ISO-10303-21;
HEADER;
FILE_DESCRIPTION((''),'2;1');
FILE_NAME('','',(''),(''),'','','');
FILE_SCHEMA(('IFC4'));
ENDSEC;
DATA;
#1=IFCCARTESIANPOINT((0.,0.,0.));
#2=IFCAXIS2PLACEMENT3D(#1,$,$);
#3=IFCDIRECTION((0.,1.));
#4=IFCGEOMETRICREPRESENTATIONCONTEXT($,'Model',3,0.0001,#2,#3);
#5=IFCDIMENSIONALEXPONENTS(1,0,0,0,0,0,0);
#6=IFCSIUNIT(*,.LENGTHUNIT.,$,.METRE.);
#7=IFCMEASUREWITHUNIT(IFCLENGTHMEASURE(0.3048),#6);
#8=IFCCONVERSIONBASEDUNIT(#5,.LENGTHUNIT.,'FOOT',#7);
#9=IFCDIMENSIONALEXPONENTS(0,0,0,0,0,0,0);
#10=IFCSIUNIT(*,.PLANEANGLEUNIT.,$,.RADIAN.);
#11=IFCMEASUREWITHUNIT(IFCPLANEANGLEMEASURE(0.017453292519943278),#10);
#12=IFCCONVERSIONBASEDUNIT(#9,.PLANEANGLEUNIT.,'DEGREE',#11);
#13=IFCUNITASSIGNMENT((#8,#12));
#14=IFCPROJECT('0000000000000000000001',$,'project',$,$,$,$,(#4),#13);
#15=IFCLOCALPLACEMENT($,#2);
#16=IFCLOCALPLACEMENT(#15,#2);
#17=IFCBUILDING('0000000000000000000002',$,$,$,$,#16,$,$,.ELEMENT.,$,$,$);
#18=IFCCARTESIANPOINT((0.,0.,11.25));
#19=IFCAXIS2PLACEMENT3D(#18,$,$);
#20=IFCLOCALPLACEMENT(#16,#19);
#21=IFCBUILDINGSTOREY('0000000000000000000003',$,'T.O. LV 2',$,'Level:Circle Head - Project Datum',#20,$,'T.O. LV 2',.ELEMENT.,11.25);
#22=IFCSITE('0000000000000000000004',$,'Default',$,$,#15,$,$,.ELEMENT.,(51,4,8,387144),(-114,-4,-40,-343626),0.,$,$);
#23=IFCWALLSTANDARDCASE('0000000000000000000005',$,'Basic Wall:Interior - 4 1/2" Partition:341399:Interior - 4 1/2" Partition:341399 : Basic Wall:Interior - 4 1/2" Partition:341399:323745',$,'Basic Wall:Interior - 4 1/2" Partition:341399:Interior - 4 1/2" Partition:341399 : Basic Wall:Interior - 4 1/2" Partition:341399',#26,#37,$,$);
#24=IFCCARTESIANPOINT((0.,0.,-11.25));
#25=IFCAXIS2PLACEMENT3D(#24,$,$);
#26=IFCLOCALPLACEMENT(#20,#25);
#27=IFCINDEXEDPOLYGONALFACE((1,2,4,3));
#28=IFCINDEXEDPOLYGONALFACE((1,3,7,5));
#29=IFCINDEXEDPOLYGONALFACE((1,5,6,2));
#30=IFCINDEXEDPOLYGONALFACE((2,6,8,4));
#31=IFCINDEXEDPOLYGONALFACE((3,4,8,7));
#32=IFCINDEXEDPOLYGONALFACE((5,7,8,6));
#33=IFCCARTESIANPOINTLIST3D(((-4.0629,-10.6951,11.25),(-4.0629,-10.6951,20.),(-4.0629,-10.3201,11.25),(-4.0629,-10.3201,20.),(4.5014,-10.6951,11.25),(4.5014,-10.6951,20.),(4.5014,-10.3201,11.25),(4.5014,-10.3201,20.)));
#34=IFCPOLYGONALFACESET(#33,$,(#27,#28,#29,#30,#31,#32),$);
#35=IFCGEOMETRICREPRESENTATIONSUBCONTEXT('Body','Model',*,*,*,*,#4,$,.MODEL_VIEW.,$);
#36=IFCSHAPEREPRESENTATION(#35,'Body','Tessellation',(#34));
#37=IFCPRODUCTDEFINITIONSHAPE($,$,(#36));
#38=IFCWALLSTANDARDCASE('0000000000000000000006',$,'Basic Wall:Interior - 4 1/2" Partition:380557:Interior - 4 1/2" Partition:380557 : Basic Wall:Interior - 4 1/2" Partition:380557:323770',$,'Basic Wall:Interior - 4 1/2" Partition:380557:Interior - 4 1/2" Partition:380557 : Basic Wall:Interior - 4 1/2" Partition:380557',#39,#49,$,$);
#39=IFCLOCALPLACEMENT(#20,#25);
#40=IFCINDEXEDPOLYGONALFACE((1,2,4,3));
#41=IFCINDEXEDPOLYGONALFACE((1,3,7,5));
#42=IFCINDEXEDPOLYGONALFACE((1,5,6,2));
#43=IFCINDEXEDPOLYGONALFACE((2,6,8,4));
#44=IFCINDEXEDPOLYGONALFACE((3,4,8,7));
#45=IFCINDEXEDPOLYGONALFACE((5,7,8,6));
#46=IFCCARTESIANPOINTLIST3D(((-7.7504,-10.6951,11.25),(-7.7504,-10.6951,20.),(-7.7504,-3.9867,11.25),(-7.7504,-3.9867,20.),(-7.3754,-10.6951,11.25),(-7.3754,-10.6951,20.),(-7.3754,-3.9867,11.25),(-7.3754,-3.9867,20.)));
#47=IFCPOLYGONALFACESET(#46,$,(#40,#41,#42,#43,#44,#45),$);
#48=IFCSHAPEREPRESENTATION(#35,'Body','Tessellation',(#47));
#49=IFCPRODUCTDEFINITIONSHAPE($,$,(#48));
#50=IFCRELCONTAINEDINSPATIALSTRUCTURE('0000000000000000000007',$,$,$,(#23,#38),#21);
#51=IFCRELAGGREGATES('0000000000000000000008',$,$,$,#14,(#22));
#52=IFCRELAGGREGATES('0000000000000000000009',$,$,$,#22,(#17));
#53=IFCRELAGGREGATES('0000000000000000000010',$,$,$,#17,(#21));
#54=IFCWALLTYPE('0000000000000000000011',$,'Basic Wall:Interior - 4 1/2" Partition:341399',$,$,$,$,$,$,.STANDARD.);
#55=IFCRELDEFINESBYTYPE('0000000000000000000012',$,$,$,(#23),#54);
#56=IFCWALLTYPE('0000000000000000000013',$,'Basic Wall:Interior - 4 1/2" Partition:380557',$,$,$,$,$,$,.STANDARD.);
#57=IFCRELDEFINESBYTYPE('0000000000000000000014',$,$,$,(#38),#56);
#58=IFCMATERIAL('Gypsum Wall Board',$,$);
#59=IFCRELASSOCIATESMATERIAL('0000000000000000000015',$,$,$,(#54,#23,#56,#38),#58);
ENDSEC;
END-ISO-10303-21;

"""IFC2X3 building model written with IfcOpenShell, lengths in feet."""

from ifc_helpers import new_model, entity, si_unit, converted_unit, direction, frame, frame_2d, origin, origin_2d_with_axis, place, context, subcontext, project, spatial, rectangle, extrude, source, transform, mapped, material, type_object, type_shapes, element, save


model = new_model("IFC2X3")

# Units and contexts
model_context = context("Model", 3, precision=0.0001, world=origin(), true_north=direction((0.0, 1.0)))
body_context = subcontext(model_context, "Body", "Model", "MODEL_VIEW")
ifc_project = project(units=[converted_unit("LENGTHUNIT", "FOOT", entity("IfcLengthMeasure", 0.3048), si_unit("LENGTHUNIT", "METRE"), dimensions=[1, 0, 0, 0, 0, 0, 0]), converted_unit("PLANEANGLEUNIT", "DEGREE", entity("IfcPlaneAngleMeasure", 0.017453292519943278), si_unit("PLANEANGLEUNIT", "RADIAN"), dimensions=[0, 0, 0, 0, 0, 0, 0])], contexts=[model_context])

# Site, building, storey
site_placement = place(None, origin())
site = spatial("IfcSite", under=ifc_project, at=site_placement, Name="Default", CompositionType="ELEMENT", RefLatitude=(51, 4, 8, 387144), RefLongitude=(-114, -4, -40, -343626), RefElevation=0.0)
building_placement = place(site_placement, origin())
building = spatial("IfcBuilding", under=site, at=building_placement, CompositionType="ELEMENT")
storey_placement = place(building_placement, frame((0.0, 0.0, 11.25)))
storey = spatial("IfcBuildingStorey", under=building, at=storey_placement, Name="T.O. LV 2", ObjectType="Level:Circle Head - Project Datum", LongName="T.O. LV 2", CompositionType="ELEMENT", Elevation=11.25)

# Walls
ifc_material_1 = material(Name="Gypsum Wall Board")
wall_type_1 = type_object("IfcWallType", Name="Basic Wall:Interior - 4 1/2\" Partition:341399", PredefinedType="STANDARD", material=ifc_material_1)
shared_shape_1 = source(origin(), body_context, "Body", "SweptSolid", [
    extrude(rectangle(XDim=8.5643, YDim=0.375, at=origin_2d_with_axis()), frame((0.2193, -10.5076, 11.25)), (0.0, 0.0, 1.0), 8.75),
])
type_shapes(wall_type_1, [shared_shape_1])
wall_1_placement = place(storey_placement, frame((0.0, 0.0, -11.25)))
element("IfcWallStandardCase", 1, at=wall_1_placement, inside=storey, type_object=wall_type_1, material=ifc_material_1, Name="Basic Wall:Interior - 4 1/2\" Partition:341399:Interior - 4 1/2\" Partition:341399 : Basic Wall:Interior - 4 1/2\" Partition:341399:323745", ObjectType="Basic Wall:Interior - 4 1/2\" Partition:341399:Interior - 4 1/2\" Partition:341399 : Basic Wall:Interior - 4 1/2\" Partition:341399", context=body_context, shape_type="MappedRepresentation", body=[
    mapped(shared_shape_1, transform((0.0, 0.0, 0.0), scale=1.0)),
])
wall_type_2 = type_object("IfcWallType", Name="Basic Wall:Interior - 4 1/2\" Partition:380557", PredefinedType="STANDARD", material=ifc_material_1)
shared_shape_2 = source(origin(), body_context, "Body", "SweptSolid", [
    extrude(rectangle(XDim=6.7083, YDim=0.375, at=frame_2d((0.0, 0.0), x_axis=(1.0, 0.0))), frame((-7.5629, -7.3409, 11.25), z_axis=(0.0, 0.0, 1.0), x_axis=(0.0, 1.0, 0.0)), (0.0, 0.0, 1.0), 8.75),
])
type_shapes(wall_type_2, [shared_shape_2])
wall_2_placement = place(storey_placement, frame((0.0, 0.0, -11.25)))
element("IfcWallStandardCase", 2, at=wall_2_placement, inside=storey, type_object=wall_type_2, material=ifc_material_1, Name="Basic Wall:Interior - 4 1/2\" Partition:380557:Interior - 4 1/2\" Partition:380557 : Basic Wall:Interior - 4 1/2\" Partition:380557:323770", ObjectType="Basic Wall:Interior - 4 1/2\" Partition:380557:Interior - 4 1/2\" Partition:380557 : Basic Wall:Interior - 4 1/2\" Partition:380557", context=body_context, shape_type="MappedRepresentation", body=[
    mapped(shared_shape_2, transform((0.0, 0.0, 0.0), scale=1.0)),
])

save(model, "model.ifc")
